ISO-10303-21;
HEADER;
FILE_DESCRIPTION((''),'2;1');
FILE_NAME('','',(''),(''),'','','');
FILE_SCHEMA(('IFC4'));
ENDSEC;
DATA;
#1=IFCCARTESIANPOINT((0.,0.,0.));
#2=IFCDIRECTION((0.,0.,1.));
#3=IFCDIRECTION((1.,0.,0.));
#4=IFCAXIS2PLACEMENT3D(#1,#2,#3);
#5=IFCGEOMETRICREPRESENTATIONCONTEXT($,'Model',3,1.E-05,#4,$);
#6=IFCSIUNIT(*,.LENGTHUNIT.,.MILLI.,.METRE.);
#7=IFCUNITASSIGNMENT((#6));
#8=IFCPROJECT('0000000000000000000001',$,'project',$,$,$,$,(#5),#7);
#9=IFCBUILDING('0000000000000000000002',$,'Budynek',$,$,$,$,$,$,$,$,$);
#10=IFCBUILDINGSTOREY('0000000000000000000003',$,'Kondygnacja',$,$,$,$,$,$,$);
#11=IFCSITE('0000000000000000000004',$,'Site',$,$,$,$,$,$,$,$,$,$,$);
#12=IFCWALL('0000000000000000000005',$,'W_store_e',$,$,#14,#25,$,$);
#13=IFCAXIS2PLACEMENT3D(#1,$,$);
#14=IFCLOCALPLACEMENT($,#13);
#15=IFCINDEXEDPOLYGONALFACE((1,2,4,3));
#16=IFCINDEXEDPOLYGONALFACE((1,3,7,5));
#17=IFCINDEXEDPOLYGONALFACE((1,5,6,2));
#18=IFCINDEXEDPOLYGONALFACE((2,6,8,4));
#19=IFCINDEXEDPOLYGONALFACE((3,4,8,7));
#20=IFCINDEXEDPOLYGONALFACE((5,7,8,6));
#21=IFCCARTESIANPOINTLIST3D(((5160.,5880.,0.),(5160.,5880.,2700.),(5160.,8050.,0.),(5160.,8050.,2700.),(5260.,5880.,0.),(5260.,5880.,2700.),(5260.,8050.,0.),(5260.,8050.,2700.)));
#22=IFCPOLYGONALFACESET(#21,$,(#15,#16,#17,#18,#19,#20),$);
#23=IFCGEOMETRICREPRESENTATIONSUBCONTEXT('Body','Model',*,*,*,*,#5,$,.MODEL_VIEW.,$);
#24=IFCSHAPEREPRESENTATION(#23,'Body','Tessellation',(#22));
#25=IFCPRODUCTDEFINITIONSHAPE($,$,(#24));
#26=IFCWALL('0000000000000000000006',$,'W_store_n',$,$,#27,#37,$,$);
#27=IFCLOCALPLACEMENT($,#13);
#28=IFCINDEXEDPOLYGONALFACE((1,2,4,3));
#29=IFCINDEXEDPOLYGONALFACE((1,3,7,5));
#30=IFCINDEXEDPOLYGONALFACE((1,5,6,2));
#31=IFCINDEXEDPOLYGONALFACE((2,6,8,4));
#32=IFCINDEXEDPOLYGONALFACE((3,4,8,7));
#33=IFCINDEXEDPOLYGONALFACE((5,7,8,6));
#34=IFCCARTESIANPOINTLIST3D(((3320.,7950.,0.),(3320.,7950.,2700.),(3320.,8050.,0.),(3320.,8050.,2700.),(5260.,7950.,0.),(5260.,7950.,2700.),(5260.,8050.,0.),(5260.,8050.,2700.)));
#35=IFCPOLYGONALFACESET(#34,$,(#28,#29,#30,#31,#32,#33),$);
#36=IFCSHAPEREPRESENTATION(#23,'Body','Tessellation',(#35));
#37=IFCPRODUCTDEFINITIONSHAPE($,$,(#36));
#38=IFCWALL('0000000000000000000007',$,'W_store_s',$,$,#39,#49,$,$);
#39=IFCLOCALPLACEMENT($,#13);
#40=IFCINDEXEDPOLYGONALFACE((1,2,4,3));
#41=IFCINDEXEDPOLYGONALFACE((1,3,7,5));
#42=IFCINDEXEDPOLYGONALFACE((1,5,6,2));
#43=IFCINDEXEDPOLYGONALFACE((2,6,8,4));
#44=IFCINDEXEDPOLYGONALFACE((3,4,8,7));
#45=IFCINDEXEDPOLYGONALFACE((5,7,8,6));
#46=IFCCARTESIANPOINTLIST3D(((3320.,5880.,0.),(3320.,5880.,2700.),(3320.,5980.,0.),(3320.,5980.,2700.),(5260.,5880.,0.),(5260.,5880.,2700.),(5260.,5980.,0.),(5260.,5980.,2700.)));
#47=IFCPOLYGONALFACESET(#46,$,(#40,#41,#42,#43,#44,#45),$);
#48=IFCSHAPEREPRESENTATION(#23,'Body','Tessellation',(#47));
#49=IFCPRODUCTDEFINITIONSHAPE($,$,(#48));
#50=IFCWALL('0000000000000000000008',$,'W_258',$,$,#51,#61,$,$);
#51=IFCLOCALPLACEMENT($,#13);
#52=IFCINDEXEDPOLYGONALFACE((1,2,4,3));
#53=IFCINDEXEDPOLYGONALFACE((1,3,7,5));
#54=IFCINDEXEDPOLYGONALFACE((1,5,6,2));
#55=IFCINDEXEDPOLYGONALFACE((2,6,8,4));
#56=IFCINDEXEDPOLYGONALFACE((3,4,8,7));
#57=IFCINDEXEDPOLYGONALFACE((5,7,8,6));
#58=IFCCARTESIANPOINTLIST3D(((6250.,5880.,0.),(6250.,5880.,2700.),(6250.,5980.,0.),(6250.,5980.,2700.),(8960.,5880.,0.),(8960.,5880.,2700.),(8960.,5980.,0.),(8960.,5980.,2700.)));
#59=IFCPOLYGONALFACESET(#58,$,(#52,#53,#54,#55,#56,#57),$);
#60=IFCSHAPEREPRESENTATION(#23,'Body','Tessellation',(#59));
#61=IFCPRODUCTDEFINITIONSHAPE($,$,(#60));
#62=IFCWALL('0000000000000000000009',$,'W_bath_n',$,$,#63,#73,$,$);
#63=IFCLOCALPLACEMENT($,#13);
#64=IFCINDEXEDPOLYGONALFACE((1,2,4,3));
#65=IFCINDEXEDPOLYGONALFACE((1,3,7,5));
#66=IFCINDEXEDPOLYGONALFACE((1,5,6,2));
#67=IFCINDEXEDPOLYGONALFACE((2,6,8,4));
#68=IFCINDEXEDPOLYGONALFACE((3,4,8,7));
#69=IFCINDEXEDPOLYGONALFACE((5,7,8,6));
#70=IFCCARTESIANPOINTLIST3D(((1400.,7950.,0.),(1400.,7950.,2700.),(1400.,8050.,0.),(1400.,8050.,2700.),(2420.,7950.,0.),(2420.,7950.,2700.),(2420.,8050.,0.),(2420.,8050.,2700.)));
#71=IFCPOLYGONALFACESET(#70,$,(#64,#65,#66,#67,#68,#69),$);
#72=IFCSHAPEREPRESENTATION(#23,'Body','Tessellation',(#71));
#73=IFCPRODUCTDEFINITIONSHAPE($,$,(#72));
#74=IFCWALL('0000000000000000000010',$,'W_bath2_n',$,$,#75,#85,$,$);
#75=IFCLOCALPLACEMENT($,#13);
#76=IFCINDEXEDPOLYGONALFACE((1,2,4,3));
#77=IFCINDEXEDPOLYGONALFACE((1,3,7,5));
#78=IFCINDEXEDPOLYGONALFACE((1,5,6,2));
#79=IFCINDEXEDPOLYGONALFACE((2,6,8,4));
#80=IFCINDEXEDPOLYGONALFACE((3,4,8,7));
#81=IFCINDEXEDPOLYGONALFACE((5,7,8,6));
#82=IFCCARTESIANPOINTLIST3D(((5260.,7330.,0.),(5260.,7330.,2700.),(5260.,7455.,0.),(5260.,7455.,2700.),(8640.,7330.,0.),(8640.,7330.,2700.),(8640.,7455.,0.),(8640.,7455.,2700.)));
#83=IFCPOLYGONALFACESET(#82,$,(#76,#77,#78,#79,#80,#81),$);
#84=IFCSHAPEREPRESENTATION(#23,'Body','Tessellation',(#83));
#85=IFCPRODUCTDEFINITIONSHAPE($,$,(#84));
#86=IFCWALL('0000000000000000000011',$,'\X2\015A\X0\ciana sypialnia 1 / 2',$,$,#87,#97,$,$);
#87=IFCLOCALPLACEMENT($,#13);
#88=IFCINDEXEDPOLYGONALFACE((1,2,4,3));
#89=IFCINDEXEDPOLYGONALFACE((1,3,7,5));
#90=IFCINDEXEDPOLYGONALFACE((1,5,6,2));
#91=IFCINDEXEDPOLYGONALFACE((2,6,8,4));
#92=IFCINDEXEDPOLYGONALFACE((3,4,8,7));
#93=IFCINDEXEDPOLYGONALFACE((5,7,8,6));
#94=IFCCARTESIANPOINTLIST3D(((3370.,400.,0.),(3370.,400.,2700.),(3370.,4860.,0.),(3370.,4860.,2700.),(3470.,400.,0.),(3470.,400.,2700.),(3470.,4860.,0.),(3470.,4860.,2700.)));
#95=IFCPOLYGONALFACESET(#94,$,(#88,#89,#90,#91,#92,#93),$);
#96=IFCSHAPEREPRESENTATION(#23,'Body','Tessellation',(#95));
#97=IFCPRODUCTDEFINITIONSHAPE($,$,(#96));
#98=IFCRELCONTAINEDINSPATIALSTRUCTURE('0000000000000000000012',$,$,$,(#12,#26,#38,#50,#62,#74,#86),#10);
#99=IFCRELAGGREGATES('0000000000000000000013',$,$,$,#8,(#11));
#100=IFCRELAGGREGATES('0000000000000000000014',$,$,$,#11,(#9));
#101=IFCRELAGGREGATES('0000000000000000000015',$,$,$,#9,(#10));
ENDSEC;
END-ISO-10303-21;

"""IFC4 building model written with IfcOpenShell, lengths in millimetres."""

from ifc_helpers import new_model, si_unit, frame, origin_with_axes, place, context, subcontext, project, spatial, indexed_curve, outline, extrude, element, save


model = new_model("IFC4")

# Units and contexts
model_context = context("Model", 3, precision=1e-05, world=origin_with_axes())
body_context = subcontext(model_context, "Body", "Model", "MODEL_VIEW")
ifc_project = project(units=[si_unit("LENGTHUNIT", "METRE", prefix="MILLI")], contexts=[model_context])

# Site, building, storey
site = spatial("IfcSite", under=ifc_project, Name="Site")
building = spatial("IfcBuilding", under=site, Name="Budynek")
storey = spatial("IfcBuildingStorey", under=building, Name="Kondygnacja")

# Walls
wall_1_placement = place(None, frame((5210.0, 5880.0, 0.0), z_axis=(0.0, 0.0, 1.0), x_axis=(0.0, 1.0, 0.0)))
element("IfcWall", 1, at=wall_1_placement, inside=storey, Name="W_store_e", context=body_context, shape_type="SweptSolid", body=[
    extrude(outline(indexed_curve([(0.0, 0.0), (0.0, 100.0), (2170.0, 100.0), (2170.0, 0.0), (0.0, 0.0)], self_intersect=False)), frame((0.0, -50.0, 0.0), z_axis=(0.0, 0.0, 1.0), x_axis=(1.0, 0.0, 0.0)), (0.0, 0.0, 1.0), 2700.0),
])
for number, where, z_axis, x_axis, name in (
    (2, (3320.0, 8000.0, 0.0), (0.0, 0.0, 1.0), (1.0, 0.0, 0.0), "W_store_n"),
    (3, (3320.0, 5930.0, 0.0), (0.0, 0.0, 1.0), (1.0, 0.0, 0.0), "W_store_s"),
):
    element("IfcWall", number, at=place(None, frame(where, z_axis=z_axis, x_axis=x_axis)), inside=storey, Name=name, context=body_context, shape_type="SweptSolid", body=[
        extrude(outline(indexed_curve([(0.0, 0.0), (0.0, 100.0), (1940.0, 100.0), (1940.0, 0.0), (0.0, 0.0)], self_intersect=False)), frame((0.0, -50.0, 0.0), z_axis=(0.0, 0.0, 1.0), x_axis=(1.0, 0.0, 0.0)), (0.0, 0.0, 1.0), 2700.0),
    ])
wall_2_placement = place(None, frame((6250.0, 5930.0, 0.0), z_axis=(0.0, 0.0, 1.0), x_axis=(1.0, 0.0, 0.0)))
element("IfcWall", 4, at=wall_2_placement, inside=storey, Name="W_258", context=body_context, shape_type="SweptSolid", body=[
    extrude(outline(indexed_curve([(0.0, 0.0), (0.0, 100.0), (2710.0, 100.0), (2710.0, 0.0), (0.0, 0.0)], self_intersect=False)), frame((0.0, -50.0, 0.0), z_axis=(0.0, 0.0, 1.0), x_axis=(1.0, 0.0, 0.0)), (0.0, 0.0, 1.0), 2700.0),
])
wall_3_placement = place(None, frame((1400.0, 8000.0, 0.0), z_axis=(0.0, 0.0, 1.0), x_axis=(1.0, 0.0, 0.0)))
element("IfcWall", 5, at=wall_3_placement, inside=storey, Name="W_bath_n", context=body_context, shape_type="SweptSolid", body=[
    extrude(outline(indexed_curve([(0.0, 0.0), (0.0, 100.0), (1020.0, 100.0), (1020.0, 0.0), (0.0, 0.0)], self_intersect=False)), frame((0.0, -50.0, 0.0), z_axis=(0.0, 0.0, 1.0), x_axis=(1.0, 0.0, 0.0)), (0.0, 0.0, 1.0), 2700.0),
])
wall_4_placement = place(None, frame((5260.0, 7392.5, 0.0), z_axis=(0.0, 0.0, 1.0), x_axis=(1.0, 0.0, 0.0)))
element("IfcWall", 6, at=wall_4_placement, inside=storey, Name="W_bath2_n", context=body_context, shape_type="SweptSolid", body=[
    extrude(outline(indexed_curve([(0.0, 0.0), (0.0, 125.0), (3380.0, 125.0), (3380.0, 0.0), (0.0, 0.0)], self_intersect=False)), frame((0.0, -62.5, 0.0), z_axis=(0.0, 0.0, 1.0), x_axis=(1.0, 0.0, 0.0)), (0.0, 0.0, 1.0), 2700.0),
])
wall_5_placement = place(None, frame((3420.0, 400.0, 0.0), z_axis=(0.0, 0.0, 1.0), x_axis=(0.0, 1.0, 0.0)))
element("IfcWall", 7, at=wall_5_placement, inside=storey, Name="Ściana sypialnia 1 / 2", context=body_context, shape_type="SweptSolid", body=[
    extrude(outline(indexed_curve([(0.0, 0.0), (0.0, 100.0), (4460.0, 100.0), (4460.0, 0.0), (0.0, 0.0)], self_intersect=False)), frame((0.0, -50.0, 0.0), z_axis=(0.0, 0.0, 1.0), x_axis=(1.0, 0.0, 0.0)), (0.0, 0.0, 1.0), 2700.0),
])

save(model, "model.ifc")
